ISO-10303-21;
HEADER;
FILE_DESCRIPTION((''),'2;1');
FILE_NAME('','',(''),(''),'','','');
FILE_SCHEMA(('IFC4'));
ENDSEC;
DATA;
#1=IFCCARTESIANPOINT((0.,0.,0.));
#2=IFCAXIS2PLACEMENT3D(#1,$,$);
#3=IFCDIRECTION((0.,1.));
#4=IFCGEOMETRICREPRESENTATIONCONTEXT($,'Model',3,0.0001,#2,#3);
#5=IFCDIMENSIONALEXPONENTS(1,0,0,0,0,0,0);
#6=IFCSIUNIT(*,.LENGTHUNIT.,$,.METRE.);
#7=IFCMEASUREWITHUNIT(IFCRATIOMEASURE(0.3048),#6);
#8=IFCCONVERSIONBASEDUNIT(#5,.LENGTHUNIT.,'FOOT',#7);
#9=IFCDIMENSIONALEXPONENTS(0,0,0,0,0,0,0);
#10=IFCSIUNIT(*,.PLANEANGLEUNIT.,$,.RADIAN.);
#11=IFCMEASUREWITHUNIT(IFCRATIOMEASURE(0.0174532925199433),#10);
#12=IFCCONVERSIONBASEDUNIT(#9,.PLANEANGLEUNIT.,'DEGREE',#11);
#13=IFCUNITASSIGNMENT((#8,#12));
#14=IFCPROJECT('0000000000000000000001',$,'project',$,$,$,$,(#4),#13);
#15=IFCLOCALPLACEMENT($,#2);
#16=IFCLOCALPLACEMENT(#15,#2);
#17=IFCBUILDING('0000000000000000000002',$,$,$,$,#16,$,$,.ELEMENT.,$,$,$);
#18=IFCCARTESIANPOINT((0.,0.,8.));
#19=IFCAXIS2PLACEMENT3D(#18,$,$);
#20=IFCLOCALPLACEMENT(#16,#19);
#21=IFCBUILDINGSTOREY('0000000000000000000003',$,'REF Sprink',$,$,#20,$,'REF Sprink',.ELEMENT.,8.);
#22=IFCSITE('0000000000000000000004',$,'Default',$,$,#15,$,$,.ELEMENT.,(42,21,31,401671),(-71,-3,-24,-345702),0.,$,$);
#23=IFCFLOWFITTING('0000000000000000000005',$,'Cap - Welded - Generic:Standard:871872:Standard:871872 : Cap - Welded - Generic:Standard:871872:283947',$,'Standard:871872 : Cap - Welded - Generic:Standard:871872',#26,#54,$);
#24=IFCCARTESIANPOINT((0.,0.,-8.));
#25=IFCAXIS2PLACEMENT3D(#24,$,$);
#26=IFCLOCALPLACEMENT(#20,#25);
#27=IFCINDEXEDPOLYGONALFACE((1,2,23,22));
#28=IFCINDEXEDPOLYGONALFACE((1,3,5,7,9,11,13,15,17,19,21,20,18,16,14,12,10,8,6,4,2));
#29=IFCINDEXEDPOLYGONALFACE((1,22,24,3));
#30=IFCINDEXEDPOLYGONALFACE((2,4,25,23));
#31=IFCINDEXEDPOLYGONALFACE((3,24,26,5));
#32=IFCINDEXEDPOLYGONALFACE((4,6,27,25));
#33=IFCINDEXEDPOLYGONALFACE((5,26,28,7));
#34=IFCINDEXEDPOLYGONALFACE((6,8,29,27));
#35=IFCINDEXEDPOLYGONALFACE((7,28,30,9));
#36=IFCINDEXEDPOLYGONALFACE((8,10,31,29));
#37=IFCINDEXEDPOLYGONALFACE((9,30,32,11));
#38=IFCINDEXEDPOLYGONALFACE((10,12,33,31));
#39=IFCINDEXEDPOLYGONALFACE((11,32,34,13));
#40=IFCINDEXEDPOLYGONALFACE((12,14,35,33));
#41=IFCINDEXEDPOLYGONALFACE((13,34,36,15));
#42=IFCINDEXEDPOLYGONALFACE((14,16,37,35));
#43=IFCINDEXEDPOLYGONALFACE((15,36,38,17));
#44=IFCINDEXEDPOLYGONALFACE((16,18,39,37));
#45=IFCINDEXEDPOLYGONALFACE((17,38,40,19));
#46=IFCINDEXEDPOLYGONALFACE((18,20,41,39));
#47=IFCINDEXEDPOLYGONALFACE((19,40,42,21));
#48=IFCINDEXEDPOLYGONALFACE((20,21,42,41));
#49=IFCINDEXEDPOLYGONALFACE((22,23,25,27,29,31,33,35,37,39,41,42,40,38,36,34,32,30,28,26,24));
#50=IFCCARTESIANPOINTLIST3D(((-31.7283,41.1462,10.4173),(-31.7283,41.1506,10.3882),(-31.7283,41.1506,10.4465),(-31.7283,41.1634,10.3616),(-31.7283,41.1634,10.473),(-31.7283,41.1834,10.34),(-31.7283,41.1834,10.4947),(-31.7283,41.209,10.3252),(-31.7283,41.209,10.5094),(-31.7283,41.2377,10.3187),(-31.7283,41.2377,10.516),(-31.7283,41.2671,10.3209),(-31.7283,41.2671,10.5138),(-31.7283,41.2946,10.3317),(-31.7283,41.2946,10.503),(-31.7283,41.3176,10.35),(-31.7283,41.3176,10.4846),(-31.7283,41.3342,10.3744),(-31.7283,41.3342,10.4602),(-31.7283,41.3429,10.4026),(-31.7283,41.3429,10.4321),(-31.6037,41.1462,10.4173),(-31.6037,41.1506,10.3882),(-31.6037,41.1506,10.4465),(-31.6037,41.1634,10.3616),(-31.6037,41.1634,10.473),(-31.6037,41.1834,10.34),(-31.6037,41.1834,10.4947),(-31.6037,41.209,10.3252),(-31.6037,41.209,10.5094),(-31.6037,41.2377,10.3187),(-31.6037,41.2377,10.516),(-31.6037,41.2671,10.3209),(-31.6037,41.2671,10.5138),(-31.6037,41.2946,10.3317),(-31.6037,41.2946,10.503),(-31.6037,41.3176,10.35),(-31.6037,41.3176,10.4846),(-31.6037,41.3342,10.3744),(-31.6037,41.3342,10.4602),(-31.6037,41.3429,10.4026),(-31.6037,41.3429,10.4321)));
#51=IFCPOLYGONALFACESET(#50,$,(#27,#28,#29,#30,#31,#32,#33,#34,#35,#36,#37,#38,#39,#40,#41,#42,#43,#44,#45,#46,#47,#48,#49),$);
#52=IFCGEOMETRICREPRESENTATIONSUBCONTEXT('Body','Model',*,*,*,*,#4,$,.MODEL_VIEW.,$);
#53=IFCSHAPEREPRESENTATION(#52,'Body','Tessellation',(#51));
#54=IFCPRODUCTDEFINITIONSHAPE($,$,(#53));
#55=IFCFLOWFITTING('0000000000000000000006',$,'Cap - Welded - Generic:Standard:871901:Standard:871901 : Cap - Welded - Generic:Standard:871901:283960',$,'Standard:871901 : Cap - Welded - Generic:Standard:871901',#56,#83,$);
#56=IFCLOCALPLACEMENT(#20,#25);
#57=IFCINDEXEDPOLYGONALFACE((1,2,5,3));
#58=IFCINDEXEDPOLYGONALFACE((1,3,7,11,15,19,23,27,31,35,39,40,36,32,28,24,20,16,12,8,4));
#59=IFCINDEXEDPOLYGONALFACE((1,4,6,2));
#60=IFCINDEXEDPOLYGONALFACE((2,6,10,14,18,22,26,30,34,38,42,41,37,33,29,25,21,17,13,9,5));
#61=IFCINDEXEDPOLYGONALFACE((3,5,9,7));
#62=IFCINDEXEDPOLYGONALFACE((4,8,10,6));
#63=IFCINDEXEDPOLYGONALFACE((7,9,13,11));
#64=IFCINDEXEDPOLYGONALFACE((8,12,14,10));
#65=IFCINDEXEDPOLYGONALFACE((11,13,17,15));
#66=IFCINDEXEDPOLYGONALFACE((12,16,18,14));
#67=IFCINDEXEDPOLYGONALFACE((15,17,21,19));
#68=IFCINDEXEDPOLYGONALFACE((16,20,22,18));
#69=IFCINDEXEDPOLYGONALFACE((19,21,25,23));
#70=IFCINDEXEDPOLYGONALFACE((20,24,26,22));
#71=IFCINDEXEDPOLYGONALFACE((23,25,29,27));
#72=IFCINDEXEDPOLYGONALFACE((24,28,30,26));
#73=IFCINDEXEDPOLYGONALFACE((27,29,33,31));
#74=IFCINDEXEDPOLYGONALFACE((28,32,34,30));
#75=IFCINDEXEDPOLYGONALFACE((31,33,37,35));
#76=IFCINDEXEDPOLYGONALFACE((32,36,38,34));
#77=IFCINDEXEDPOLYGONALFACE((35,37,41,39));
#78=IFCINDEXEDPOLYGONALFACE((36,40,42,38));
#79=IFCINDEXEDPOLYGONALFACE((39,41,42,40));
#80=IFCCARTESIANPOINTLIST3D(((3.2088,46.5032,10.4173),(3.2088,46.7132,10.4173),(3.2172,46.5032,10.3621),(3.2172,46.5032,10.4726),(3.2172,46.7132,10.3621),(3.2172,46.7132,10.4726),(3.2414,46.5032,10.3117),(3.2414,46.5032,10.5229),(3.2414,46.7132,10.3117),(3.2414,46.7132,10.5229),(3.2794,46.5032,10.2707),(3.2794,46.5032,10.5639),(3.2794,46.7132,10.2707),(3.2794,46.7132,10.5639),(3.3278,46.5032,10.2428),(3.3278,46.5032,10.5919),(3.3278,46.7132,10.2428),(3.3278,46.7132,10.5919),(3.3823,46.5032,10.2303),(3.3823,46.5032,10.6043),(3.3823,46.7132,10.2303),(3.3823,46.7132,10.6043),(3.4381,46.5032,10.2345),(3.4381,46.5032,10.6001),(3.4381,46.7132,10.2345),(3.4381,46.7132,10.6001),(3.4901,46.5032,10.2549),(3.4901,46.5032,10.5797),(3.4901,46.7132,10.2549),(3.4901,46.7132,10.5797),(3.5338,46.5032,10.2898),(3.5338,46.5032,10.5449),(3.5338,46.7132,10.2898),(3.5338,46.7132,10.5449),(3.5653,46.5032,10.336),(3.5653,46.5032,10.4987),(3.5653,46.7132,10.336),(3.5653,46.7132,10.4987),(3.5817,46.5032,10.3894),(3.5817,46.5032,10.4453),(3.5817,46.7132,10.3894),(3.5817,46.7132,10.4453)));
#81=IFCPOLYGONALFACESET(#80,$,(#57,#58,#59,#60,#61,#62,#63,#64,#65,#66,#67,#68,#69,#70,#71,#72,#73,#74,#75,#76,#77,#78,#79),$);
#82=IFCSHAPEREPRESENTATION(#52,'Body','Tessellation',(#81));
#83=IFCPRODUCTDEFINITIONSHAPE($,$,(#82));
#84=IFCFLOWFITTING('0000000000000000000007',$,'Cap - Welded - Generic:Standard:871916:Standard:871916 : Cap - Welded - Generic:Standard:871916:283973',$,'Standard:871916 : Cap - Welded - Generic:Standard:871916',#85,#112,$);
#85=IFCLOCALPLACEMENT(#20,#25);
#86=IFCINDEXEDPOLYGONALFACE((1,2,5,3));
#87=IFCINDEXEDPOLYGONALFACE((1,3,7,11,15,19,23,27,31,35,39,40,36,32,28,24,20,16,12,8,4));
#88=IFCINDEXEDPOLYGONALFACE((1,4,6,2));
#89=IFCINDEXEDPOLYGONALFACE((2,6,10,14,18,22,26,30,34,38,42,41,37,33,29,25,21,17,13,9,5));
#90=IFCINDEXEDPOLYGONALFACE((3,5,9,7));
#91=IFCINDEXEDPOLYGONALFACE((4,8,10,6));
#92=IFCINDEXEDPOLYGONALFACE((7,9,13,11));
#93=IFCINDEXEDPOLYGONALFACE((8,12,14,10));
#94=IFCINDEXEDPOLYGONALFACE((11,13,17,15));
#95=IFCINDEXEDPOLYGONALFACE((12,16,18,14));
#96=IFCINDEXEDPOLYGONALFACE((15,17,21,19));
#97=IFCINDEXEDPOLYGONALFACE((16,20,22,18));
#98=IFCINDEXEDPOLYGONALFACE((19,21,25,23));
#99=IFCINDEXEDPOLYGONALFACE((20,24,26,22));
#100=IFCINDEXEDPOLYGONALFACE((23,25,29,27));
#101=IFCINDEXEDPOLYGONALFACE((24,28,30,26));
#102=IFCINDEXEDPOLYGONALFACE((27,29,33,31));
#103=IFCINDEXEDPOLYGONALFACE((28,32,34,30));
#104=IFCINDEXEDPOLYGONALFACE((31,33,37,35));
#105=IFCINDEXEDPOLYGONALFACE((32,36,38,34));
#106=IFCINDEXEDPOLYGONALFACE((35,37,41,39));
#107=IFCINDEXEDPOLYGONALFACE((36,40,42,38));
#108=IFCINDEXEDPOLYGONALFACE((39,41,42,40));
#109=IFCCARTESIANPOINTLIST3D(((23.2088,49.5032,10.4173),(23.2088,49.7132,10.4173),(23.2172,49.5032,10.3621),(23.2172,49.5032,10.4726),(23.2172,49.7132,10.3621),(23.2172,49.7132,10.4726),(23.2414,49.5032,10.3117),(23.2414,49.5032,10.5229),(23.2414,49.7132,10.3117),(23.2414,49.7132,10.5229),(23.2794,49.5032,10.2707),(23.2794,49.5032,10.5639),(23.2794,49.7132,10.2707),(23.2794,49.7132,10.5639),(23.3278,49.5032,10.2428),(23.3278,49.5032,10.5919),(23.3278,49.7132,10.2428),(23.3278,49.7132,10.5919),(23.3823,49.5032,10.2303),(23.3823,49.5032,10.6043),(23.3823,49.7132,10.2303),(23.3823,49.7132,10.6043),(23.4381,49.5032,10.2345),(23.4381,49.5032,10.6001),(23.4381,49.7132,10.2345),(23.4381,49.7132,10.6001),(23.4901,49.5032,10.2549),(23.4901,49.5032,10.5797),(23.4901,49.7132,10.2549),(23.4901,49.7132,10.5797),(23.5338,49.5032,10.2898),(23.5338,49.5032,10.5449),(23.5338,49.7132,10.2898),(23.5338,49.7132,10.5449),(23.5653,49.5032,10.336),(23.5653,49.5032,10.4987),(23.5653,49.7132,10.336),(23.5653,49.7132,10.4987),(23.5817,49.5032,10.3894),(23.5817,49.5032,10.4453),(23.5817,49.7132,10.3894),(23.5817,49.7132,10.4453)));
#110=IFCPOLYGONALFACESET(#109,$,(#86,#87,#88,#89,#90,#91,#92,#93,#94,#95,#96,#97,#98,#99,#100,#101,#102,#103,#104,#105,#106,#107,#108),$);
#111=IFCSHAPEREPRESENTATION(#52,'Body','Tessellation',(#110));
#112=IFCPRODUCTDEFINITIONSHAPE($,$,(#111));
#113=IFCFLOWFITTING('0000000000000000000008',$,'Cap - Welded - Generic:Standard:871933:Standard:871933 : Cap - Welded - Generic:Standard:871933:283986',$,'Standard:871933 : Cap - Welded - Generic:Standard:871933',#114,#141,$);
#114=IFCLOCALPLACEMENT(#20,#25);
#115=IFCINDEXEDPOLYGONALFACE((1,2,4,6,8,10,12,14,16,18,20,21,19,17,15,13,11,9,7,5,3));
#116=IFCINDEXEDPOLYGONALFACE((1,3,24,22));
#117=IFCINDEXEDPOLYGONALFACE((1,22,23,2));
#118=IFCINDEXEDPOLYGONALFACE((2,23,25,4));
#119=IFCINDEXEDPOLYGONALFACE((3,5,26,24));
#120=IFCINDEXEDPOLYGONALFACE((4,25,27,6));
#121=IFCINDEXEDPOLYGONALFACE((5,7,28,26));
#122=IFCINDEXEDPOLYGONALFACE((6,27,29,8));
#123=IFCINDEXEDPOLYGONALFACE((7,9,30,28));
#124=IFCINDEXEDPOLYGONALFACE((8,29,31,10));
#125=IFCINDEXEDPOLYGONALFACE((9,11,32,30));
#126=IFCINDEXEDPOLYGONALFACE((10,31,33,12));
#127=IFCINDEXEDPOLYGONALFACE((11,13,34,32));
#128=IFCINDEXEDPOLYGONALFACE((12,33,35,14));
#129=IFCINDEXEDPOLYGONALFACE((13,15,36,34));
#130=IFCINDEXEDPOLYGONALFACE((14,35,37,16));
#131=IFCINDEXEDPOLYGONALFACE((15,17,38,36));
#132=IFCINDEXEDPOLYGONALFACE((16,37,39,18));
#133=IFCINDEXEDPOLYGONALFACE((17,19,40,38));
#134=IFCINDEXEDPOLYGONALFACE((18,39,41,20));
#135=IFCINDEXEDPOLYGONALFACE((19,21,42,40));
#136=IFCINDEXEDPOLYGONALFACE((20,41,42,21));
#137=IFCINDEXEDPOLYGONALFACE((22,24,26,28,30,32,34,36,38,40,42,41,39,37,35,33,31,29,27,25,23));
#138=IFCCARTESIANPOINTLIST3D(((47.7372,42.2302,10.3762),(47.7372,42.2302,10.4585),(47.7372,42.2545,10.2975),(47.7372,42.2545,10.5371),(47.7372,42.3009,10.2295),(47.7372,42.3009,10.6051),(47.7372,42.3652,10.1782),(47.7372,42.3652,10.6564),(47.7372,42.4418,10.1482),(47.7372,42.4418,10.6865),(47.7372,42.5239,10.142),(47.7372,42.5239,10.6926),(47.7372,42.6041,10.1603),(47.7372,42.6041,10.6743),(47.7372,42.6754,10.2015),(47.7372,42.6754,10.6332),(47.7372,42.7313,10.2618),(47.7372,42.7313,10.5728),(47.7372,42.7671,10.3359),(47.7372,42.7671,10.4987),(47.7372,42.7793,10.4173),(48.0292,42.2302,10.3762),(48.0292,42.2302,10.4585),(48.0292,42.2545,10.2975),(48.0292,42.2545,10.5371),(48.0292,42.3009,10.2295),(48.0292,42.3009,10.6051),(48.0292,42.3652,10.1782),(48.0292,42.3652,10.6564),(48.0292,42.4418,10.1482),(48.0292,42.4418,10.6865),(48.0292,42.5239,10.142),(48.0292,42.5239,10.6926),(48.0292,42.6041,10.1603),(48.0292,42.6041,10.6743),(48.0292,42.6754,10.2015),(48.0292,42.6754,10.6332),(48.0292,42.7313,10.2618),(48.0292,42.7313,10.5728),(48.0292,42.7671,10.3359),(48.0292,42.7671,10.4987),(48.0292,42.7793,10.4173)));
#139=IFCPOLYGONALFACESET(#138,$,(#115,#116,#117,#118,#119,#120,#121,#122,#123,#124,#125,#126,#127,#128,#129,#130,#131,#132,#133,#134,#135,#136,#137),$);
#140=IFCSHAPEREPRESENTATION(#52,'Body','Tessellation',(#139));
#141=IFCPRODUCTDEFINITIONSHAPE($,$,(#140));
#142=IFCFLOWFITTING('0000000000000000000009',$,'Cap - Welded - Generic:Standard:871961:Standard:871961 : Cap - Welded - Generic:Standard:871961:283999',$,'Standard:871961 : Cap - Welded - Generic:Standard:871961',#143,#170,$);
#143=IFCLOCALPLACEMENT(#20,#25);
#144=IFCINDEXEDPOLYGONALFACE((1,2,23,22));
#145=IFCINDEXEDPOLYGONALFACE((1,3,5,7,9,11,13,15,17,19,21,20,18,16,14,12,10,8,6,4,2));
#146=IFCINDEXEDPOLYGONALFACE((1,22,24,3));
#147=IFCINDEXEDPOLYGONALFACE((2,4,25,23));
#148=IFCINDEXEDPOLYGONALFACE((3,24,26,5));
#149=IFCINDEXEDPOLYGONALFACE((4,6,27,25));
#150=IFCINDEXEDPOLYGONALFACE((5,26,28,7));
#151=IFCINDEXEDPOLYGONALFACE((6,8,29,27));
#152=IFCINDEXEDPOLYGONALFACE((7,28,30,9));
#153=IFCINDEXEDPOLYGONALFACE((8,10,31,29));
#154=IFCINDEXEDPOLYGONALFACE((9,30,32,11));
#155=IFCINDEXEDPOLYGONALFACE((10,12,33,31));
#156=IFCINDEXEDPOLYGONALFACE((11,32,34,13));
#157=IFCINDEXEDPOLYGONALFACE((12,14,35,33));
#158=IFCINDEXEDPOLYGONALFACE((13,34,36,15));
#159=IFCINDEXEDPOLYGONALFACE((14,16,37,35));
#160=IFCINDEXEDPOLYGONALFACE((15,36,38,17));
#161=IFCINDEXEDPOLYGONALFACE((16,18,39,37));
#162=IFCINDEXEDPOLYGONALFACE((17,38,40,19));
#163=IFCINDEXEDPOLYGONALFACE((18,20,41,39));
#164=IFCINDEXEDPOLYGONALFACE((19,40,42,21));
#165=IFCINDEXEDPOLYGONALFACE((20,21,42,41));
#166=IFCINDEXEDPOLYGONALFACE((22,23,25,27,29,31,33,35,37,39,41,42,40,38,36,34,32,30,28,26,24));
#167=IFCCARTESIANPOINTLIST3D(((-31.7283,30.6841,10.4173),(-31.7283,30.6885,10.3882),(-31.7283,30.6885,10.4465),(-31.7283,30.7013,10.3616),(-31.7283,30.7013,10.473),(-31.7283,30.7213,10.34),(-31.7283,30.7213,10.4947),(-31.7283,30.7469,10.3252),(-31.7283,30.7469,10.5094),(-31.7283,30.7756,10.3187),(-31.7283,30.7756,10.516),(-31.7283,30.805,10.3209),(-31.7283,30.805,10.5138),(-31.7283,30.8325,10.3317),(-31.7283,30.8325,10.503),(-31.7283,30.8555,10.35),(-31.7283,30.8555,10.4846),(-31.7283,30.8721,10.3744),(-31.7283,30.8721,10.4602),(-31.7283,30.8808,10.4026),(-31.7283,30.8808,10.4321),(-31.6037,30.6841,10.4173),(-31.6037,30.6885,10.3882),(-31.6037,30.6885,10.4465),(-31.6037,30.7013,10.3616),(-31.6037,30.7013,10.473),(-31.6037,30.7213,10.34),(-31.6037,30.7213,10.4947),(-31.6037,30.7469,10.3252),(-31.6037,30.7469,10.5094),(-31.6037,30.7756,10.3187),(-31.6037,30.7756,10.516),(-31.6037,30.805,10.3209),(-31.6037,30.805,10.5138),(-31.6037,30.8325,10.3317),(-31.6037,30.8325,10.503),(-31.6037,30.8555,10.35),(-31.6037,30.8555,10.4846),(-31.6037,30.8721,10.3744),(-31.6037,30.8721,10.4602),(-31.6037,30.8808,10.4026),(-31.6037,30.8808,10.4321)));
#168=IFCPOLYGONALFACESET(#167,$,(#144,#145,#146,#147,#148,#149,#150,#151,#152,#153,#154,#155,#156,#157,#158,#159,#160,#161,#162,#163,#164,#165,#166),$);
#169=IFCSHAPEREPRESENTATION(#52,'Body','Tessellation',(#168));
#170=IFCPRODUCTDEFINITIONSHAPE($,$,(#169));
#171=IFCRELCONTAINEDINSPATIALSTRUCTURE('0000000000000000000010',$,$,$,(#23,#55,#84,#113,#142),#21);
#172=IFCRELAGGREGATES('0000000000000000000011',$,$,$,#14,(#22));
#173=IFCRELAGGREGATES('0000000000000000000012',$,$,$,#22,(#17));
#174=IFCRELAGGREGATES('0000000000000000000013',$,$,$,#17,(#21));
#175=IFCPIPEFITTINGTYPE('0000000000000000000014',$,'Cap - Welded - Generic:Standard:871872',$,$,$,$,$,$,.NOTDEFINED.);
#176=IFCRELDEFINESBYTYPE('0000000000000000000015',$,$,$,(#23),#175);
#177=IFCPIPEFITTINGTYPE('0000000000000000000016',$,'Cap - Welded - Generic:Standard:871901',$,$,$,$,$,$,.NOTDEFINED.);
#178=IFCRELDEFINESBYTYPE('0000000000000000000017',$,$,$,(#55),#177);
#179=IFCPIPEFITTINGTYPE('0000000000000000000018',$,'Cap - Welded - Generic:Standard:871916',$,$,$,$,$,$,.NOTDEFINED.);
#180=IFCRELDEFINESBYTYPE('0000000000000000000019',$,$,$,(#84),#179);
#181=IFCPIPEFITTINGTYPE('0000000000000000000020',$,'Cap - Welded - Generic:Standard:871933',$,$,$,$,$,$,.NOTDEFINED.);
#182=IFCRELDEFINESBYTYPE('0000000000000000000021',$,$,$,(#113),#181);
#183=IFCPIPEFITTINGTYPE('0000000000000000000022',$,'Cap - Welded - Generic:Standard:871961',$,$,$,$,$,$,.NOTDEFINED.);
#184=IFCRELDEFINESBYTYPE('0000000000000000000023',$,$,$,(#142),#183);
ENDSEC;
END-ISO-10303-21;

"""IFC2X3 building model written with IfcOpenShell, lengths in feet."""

from ifc_helpers import new_model, entity, si_unit, converted_unit, direction, frame, frame_2d, origin, origin_2d_with_axis, place, context, subcontext, project, spatial, circle, extrude, source, transform, mapped, type_object, type_shapes, element, save


model = new_model("IFC2X3")

# Units and contexts
model_context = context("Model", 3, precision=0.0001, world=origin(), true_north=direction((0.0, 1.0)))
body_context = subcontext(model_context, "Body", "Model", "MODEL_VIEW")
ifc_project = project(units=[converted_unit("LENGTHUNIT", "FOOT", entity("IfcRatioMeasure", 0.3048), si_unit("LENGTHUNIT", "METRE"), dimensions=[1, 0, 0, 0, 0, 0, 0]), converted_unit("PLANEANGLEUNIT", "DEGREE", entity("IfcRatioMeasure", 0.0174532925199433), si_unit("PLANEANGLEUNIT", "RADIAN"), dimensions=[0, 0, 0, 0, 0, 0, 0])], contexts=[model_context])

# Site, building, storey
site_placement = place(None, origin())
site = spatial("IfcSite", under=ifc_project, at=site_placement, Name="Default", CompositionType="ELEMENT", RefLatitude=(42, 21, 31, 401671), RefLongitude=(-71, -3, -24, -345702), RefElevation=0.0)
building_placement = place(site_placement, origin())
building = spatial("IfcBuilding", under=site, at=building_placement, CompositionType="ELEMENT")
storey_placement = place(building_placement, frame((0.0, 0.0, 8.0)))
storey = spatial("IfcBuildingStorey", under=building, at=storey_placement, Name="REF Sprink", LongName="REF Sprink", CompositionType="ELEMENT", Elevation=8.0)

# Flow fittings
pipe_fitting_type_1 = type_object("IfcPipeFittingType", Name="Cap - Welded - Generic:Standard:871872", PredefinedType="NOTDEFINED")
shared_shape_1 = source(origin(), body_context, "Body", "SweptSolid", [
    extrude(circle(Radius=0.0989, at=origin_2d_with_axis()), frame((-31.7283, 41.2451, 10.4173), z_axis=(1.0, 0.0, 0.0), x_axis=(0.0, -1.0, 0.0)), (0.0, 0.0, 1.0), 0.1247),
])
type_shapes(pipe_fitting_type_1, [shared_shape_1])
flow_fitting_1_placement = place(storey_placement, frame((0.0, 0.0, -8.0)))
element("IfcFlowFitting", 1, at=flow_fitting_1_placement, inside=storey, type_object=pipe_fitting_type_1, Name="Cap - Welded - Generic:Standard:871872:Standard:871872 : Cap - Welded - Generic:Standard:871872:283947", ObjectType="Standard:871872 : Cap - Welded - Generic:Standard:871872", context=body_context, shape_type="MappedRepresentation", body=[
    mapped(shared_shape_1, transform((0.0, 0.0, 0.0), scale=1.0)),
])
pipe_fitting_type_2 = type_object("IfcPipeFittingType", Name="Cap - Welded - Generic:Standard:871901", PredefinedType="NOTDEFINED")
shared_shape_2 = source(origin(), body_context, "Body", "SweptSolid", [
    extrude(circle(Radius=0.1875, at=origin_2d_with_axis()), frame((3.3963, 46.5032, 10.4173), z_axis=(0.0, 1.0, 0.0), x_axis=(-1.0, 0.0, 0.0)), (0.0, 0.0, 1.0), 0.21),
])
type_shapes(pipe_fitting_type_2, [shared_shape_2])
flow_fitting_2_placement = place(storey_placement, frame((0.0, 0.0, -8.0)))
element("IfcFlowFitting", 2, at=flow_fitting_2_placement, inside=storey, type_object=pipe_fitting_type_2, Name="Cap - Welded - Generic:Standard:871901:Standard:871901 : Cap - Welded - Generic:Standard:871901:283960", ObjectType="Standard:871901 : Cap - Welded - Generic:Standard:871901", context=body_context, shape_type="MappedRepresentation", body=[
    mapped(shared_shape_2, transform((0.0, 0.0, 0.0), scale=1.0)),
])
pipe_fitting_type_3 = type_object("IfcPipeFittingType", Name="Cap - Welded - Generic:Standard:871916", PredefinedType="NOTDEFINED")
shared_shape_3 = source(origin(), body_context, "Body", "SweptSolid", [
    extrude(circle(Radius=0.1875, at=origin_2d_with_axis()), frame((23.3963, 49.5032, 10.4173), z_axis=(0.0, 1.0, 0.0), x_axis=(-1.0, 0.0, 0.0)), (0.0, 0.0, 1.0), 0.21),
])
type_shapes(pipe_fitting_type_3, [shared_shape_3])
flow_fitting_3_placement = place(storey_placement, frame((0.0, 0.0, -8.0)))
element("IfcFlowFitting", 3, at=flow_fitting_3_placement, inside=storey, type_object=pipe_fitting_type_3, Name="Cap - Welded - Generic:Standard:871916:Standard:871916 : Cap - Welded - Generic:Standard:871916:283973", ObjectType="Standard:871916 : Cap - Welded - Generic:Standard:871916", context=body_context, shape_type="MappedRepresentation", body=[
    mapped(shared_shape_3, transform((0.0, 0.0, 0.0), scale=1.0)),
])
pipe_fitting_type_4 = type_object("IfcPipeFittingType", Name="Cap - Welded - Generic:Standard:871933", PredefinedType="NOTDEFINED")
shared_shape_4 = source(origin(), body_context, "Body", "SweptSolid", [
    extrude(circle(Radius=0.2761, at=frame_2d((0.0, 0.0), x_axis=(1.0, 0.0))), frame((47.7372, 42.5032, 10.4173), z_axis=(1.0, 0.0, 0.0), x_axis=(0.0, 1.0, 0.0)), (0.0, 0.0, 1.0), 0.292),
])
type_shapes(pipe_fitting_type_4, [shared_shape_4])
flow_fitting_4_placement = place(storey_placement, frame((0.0, 0.0, -8.0)))
element("IfcFlowFitting", 4, at=flow_fitting_4_placement, inside=storey, type_object=pipe_fitting_type_4, Name="Cap - Welded - Generic:Standard:871933:Standard:871933 : Cap - Welded - Generic:Standard:871933:283986", ObjectType="Standard:871933 : Cap - Welded - Generic:Standard:871933", context=body_context, shape_type="MappedRepresentation", body=[
    mapped(shared_shape_4, transform((0.0, 0.0, 0.0), scale=1.0)),
])
pipe_fitting_type_5 = type_object("IfcPipeFittingType", Name="Cap - Welded - Generic:Standard:871961", PredefinedType="NOTDEFINED")
shared_shape_5 = source(origin(), body_context, "Body", "SweptSolid", [
    extrude(circle(Radius=0.0989, at=origin_2d_with_axis()), frame((-31.7283, 30.783, 10.4173), z_axis=(1.0, 0.0, 0.0), x_axis=(0.0, -1.0, 0.0)), (0.0, 0.0, 1.0), 0.1247),
])
type_shapes(pipe_fitting_type_5, [shared_shape_5])
flow_fitting_5_placement = place(storey_placement, frame((0.0, 0.0, -8.0)))
element("IfcFlowFitting", 5, at=flow_fitting_5_placement, inside=storey, type_object=pipe_fitting_type_5, Name="Cap - Welded - Generic:Standard:871961:Standard:871961 : Cap - Welded - Generic:Standard:871961:283999", ObjectType="Standard:871961 : Cap - Welded - Generic:Standard:871961", context=body_context, shape_type="MappedRepresentation", body=[
    mapped(shared_shape_5, transform((0.0, 0.0, 0.0), scale=1.0)),
])

save(model, "model.ifc")
